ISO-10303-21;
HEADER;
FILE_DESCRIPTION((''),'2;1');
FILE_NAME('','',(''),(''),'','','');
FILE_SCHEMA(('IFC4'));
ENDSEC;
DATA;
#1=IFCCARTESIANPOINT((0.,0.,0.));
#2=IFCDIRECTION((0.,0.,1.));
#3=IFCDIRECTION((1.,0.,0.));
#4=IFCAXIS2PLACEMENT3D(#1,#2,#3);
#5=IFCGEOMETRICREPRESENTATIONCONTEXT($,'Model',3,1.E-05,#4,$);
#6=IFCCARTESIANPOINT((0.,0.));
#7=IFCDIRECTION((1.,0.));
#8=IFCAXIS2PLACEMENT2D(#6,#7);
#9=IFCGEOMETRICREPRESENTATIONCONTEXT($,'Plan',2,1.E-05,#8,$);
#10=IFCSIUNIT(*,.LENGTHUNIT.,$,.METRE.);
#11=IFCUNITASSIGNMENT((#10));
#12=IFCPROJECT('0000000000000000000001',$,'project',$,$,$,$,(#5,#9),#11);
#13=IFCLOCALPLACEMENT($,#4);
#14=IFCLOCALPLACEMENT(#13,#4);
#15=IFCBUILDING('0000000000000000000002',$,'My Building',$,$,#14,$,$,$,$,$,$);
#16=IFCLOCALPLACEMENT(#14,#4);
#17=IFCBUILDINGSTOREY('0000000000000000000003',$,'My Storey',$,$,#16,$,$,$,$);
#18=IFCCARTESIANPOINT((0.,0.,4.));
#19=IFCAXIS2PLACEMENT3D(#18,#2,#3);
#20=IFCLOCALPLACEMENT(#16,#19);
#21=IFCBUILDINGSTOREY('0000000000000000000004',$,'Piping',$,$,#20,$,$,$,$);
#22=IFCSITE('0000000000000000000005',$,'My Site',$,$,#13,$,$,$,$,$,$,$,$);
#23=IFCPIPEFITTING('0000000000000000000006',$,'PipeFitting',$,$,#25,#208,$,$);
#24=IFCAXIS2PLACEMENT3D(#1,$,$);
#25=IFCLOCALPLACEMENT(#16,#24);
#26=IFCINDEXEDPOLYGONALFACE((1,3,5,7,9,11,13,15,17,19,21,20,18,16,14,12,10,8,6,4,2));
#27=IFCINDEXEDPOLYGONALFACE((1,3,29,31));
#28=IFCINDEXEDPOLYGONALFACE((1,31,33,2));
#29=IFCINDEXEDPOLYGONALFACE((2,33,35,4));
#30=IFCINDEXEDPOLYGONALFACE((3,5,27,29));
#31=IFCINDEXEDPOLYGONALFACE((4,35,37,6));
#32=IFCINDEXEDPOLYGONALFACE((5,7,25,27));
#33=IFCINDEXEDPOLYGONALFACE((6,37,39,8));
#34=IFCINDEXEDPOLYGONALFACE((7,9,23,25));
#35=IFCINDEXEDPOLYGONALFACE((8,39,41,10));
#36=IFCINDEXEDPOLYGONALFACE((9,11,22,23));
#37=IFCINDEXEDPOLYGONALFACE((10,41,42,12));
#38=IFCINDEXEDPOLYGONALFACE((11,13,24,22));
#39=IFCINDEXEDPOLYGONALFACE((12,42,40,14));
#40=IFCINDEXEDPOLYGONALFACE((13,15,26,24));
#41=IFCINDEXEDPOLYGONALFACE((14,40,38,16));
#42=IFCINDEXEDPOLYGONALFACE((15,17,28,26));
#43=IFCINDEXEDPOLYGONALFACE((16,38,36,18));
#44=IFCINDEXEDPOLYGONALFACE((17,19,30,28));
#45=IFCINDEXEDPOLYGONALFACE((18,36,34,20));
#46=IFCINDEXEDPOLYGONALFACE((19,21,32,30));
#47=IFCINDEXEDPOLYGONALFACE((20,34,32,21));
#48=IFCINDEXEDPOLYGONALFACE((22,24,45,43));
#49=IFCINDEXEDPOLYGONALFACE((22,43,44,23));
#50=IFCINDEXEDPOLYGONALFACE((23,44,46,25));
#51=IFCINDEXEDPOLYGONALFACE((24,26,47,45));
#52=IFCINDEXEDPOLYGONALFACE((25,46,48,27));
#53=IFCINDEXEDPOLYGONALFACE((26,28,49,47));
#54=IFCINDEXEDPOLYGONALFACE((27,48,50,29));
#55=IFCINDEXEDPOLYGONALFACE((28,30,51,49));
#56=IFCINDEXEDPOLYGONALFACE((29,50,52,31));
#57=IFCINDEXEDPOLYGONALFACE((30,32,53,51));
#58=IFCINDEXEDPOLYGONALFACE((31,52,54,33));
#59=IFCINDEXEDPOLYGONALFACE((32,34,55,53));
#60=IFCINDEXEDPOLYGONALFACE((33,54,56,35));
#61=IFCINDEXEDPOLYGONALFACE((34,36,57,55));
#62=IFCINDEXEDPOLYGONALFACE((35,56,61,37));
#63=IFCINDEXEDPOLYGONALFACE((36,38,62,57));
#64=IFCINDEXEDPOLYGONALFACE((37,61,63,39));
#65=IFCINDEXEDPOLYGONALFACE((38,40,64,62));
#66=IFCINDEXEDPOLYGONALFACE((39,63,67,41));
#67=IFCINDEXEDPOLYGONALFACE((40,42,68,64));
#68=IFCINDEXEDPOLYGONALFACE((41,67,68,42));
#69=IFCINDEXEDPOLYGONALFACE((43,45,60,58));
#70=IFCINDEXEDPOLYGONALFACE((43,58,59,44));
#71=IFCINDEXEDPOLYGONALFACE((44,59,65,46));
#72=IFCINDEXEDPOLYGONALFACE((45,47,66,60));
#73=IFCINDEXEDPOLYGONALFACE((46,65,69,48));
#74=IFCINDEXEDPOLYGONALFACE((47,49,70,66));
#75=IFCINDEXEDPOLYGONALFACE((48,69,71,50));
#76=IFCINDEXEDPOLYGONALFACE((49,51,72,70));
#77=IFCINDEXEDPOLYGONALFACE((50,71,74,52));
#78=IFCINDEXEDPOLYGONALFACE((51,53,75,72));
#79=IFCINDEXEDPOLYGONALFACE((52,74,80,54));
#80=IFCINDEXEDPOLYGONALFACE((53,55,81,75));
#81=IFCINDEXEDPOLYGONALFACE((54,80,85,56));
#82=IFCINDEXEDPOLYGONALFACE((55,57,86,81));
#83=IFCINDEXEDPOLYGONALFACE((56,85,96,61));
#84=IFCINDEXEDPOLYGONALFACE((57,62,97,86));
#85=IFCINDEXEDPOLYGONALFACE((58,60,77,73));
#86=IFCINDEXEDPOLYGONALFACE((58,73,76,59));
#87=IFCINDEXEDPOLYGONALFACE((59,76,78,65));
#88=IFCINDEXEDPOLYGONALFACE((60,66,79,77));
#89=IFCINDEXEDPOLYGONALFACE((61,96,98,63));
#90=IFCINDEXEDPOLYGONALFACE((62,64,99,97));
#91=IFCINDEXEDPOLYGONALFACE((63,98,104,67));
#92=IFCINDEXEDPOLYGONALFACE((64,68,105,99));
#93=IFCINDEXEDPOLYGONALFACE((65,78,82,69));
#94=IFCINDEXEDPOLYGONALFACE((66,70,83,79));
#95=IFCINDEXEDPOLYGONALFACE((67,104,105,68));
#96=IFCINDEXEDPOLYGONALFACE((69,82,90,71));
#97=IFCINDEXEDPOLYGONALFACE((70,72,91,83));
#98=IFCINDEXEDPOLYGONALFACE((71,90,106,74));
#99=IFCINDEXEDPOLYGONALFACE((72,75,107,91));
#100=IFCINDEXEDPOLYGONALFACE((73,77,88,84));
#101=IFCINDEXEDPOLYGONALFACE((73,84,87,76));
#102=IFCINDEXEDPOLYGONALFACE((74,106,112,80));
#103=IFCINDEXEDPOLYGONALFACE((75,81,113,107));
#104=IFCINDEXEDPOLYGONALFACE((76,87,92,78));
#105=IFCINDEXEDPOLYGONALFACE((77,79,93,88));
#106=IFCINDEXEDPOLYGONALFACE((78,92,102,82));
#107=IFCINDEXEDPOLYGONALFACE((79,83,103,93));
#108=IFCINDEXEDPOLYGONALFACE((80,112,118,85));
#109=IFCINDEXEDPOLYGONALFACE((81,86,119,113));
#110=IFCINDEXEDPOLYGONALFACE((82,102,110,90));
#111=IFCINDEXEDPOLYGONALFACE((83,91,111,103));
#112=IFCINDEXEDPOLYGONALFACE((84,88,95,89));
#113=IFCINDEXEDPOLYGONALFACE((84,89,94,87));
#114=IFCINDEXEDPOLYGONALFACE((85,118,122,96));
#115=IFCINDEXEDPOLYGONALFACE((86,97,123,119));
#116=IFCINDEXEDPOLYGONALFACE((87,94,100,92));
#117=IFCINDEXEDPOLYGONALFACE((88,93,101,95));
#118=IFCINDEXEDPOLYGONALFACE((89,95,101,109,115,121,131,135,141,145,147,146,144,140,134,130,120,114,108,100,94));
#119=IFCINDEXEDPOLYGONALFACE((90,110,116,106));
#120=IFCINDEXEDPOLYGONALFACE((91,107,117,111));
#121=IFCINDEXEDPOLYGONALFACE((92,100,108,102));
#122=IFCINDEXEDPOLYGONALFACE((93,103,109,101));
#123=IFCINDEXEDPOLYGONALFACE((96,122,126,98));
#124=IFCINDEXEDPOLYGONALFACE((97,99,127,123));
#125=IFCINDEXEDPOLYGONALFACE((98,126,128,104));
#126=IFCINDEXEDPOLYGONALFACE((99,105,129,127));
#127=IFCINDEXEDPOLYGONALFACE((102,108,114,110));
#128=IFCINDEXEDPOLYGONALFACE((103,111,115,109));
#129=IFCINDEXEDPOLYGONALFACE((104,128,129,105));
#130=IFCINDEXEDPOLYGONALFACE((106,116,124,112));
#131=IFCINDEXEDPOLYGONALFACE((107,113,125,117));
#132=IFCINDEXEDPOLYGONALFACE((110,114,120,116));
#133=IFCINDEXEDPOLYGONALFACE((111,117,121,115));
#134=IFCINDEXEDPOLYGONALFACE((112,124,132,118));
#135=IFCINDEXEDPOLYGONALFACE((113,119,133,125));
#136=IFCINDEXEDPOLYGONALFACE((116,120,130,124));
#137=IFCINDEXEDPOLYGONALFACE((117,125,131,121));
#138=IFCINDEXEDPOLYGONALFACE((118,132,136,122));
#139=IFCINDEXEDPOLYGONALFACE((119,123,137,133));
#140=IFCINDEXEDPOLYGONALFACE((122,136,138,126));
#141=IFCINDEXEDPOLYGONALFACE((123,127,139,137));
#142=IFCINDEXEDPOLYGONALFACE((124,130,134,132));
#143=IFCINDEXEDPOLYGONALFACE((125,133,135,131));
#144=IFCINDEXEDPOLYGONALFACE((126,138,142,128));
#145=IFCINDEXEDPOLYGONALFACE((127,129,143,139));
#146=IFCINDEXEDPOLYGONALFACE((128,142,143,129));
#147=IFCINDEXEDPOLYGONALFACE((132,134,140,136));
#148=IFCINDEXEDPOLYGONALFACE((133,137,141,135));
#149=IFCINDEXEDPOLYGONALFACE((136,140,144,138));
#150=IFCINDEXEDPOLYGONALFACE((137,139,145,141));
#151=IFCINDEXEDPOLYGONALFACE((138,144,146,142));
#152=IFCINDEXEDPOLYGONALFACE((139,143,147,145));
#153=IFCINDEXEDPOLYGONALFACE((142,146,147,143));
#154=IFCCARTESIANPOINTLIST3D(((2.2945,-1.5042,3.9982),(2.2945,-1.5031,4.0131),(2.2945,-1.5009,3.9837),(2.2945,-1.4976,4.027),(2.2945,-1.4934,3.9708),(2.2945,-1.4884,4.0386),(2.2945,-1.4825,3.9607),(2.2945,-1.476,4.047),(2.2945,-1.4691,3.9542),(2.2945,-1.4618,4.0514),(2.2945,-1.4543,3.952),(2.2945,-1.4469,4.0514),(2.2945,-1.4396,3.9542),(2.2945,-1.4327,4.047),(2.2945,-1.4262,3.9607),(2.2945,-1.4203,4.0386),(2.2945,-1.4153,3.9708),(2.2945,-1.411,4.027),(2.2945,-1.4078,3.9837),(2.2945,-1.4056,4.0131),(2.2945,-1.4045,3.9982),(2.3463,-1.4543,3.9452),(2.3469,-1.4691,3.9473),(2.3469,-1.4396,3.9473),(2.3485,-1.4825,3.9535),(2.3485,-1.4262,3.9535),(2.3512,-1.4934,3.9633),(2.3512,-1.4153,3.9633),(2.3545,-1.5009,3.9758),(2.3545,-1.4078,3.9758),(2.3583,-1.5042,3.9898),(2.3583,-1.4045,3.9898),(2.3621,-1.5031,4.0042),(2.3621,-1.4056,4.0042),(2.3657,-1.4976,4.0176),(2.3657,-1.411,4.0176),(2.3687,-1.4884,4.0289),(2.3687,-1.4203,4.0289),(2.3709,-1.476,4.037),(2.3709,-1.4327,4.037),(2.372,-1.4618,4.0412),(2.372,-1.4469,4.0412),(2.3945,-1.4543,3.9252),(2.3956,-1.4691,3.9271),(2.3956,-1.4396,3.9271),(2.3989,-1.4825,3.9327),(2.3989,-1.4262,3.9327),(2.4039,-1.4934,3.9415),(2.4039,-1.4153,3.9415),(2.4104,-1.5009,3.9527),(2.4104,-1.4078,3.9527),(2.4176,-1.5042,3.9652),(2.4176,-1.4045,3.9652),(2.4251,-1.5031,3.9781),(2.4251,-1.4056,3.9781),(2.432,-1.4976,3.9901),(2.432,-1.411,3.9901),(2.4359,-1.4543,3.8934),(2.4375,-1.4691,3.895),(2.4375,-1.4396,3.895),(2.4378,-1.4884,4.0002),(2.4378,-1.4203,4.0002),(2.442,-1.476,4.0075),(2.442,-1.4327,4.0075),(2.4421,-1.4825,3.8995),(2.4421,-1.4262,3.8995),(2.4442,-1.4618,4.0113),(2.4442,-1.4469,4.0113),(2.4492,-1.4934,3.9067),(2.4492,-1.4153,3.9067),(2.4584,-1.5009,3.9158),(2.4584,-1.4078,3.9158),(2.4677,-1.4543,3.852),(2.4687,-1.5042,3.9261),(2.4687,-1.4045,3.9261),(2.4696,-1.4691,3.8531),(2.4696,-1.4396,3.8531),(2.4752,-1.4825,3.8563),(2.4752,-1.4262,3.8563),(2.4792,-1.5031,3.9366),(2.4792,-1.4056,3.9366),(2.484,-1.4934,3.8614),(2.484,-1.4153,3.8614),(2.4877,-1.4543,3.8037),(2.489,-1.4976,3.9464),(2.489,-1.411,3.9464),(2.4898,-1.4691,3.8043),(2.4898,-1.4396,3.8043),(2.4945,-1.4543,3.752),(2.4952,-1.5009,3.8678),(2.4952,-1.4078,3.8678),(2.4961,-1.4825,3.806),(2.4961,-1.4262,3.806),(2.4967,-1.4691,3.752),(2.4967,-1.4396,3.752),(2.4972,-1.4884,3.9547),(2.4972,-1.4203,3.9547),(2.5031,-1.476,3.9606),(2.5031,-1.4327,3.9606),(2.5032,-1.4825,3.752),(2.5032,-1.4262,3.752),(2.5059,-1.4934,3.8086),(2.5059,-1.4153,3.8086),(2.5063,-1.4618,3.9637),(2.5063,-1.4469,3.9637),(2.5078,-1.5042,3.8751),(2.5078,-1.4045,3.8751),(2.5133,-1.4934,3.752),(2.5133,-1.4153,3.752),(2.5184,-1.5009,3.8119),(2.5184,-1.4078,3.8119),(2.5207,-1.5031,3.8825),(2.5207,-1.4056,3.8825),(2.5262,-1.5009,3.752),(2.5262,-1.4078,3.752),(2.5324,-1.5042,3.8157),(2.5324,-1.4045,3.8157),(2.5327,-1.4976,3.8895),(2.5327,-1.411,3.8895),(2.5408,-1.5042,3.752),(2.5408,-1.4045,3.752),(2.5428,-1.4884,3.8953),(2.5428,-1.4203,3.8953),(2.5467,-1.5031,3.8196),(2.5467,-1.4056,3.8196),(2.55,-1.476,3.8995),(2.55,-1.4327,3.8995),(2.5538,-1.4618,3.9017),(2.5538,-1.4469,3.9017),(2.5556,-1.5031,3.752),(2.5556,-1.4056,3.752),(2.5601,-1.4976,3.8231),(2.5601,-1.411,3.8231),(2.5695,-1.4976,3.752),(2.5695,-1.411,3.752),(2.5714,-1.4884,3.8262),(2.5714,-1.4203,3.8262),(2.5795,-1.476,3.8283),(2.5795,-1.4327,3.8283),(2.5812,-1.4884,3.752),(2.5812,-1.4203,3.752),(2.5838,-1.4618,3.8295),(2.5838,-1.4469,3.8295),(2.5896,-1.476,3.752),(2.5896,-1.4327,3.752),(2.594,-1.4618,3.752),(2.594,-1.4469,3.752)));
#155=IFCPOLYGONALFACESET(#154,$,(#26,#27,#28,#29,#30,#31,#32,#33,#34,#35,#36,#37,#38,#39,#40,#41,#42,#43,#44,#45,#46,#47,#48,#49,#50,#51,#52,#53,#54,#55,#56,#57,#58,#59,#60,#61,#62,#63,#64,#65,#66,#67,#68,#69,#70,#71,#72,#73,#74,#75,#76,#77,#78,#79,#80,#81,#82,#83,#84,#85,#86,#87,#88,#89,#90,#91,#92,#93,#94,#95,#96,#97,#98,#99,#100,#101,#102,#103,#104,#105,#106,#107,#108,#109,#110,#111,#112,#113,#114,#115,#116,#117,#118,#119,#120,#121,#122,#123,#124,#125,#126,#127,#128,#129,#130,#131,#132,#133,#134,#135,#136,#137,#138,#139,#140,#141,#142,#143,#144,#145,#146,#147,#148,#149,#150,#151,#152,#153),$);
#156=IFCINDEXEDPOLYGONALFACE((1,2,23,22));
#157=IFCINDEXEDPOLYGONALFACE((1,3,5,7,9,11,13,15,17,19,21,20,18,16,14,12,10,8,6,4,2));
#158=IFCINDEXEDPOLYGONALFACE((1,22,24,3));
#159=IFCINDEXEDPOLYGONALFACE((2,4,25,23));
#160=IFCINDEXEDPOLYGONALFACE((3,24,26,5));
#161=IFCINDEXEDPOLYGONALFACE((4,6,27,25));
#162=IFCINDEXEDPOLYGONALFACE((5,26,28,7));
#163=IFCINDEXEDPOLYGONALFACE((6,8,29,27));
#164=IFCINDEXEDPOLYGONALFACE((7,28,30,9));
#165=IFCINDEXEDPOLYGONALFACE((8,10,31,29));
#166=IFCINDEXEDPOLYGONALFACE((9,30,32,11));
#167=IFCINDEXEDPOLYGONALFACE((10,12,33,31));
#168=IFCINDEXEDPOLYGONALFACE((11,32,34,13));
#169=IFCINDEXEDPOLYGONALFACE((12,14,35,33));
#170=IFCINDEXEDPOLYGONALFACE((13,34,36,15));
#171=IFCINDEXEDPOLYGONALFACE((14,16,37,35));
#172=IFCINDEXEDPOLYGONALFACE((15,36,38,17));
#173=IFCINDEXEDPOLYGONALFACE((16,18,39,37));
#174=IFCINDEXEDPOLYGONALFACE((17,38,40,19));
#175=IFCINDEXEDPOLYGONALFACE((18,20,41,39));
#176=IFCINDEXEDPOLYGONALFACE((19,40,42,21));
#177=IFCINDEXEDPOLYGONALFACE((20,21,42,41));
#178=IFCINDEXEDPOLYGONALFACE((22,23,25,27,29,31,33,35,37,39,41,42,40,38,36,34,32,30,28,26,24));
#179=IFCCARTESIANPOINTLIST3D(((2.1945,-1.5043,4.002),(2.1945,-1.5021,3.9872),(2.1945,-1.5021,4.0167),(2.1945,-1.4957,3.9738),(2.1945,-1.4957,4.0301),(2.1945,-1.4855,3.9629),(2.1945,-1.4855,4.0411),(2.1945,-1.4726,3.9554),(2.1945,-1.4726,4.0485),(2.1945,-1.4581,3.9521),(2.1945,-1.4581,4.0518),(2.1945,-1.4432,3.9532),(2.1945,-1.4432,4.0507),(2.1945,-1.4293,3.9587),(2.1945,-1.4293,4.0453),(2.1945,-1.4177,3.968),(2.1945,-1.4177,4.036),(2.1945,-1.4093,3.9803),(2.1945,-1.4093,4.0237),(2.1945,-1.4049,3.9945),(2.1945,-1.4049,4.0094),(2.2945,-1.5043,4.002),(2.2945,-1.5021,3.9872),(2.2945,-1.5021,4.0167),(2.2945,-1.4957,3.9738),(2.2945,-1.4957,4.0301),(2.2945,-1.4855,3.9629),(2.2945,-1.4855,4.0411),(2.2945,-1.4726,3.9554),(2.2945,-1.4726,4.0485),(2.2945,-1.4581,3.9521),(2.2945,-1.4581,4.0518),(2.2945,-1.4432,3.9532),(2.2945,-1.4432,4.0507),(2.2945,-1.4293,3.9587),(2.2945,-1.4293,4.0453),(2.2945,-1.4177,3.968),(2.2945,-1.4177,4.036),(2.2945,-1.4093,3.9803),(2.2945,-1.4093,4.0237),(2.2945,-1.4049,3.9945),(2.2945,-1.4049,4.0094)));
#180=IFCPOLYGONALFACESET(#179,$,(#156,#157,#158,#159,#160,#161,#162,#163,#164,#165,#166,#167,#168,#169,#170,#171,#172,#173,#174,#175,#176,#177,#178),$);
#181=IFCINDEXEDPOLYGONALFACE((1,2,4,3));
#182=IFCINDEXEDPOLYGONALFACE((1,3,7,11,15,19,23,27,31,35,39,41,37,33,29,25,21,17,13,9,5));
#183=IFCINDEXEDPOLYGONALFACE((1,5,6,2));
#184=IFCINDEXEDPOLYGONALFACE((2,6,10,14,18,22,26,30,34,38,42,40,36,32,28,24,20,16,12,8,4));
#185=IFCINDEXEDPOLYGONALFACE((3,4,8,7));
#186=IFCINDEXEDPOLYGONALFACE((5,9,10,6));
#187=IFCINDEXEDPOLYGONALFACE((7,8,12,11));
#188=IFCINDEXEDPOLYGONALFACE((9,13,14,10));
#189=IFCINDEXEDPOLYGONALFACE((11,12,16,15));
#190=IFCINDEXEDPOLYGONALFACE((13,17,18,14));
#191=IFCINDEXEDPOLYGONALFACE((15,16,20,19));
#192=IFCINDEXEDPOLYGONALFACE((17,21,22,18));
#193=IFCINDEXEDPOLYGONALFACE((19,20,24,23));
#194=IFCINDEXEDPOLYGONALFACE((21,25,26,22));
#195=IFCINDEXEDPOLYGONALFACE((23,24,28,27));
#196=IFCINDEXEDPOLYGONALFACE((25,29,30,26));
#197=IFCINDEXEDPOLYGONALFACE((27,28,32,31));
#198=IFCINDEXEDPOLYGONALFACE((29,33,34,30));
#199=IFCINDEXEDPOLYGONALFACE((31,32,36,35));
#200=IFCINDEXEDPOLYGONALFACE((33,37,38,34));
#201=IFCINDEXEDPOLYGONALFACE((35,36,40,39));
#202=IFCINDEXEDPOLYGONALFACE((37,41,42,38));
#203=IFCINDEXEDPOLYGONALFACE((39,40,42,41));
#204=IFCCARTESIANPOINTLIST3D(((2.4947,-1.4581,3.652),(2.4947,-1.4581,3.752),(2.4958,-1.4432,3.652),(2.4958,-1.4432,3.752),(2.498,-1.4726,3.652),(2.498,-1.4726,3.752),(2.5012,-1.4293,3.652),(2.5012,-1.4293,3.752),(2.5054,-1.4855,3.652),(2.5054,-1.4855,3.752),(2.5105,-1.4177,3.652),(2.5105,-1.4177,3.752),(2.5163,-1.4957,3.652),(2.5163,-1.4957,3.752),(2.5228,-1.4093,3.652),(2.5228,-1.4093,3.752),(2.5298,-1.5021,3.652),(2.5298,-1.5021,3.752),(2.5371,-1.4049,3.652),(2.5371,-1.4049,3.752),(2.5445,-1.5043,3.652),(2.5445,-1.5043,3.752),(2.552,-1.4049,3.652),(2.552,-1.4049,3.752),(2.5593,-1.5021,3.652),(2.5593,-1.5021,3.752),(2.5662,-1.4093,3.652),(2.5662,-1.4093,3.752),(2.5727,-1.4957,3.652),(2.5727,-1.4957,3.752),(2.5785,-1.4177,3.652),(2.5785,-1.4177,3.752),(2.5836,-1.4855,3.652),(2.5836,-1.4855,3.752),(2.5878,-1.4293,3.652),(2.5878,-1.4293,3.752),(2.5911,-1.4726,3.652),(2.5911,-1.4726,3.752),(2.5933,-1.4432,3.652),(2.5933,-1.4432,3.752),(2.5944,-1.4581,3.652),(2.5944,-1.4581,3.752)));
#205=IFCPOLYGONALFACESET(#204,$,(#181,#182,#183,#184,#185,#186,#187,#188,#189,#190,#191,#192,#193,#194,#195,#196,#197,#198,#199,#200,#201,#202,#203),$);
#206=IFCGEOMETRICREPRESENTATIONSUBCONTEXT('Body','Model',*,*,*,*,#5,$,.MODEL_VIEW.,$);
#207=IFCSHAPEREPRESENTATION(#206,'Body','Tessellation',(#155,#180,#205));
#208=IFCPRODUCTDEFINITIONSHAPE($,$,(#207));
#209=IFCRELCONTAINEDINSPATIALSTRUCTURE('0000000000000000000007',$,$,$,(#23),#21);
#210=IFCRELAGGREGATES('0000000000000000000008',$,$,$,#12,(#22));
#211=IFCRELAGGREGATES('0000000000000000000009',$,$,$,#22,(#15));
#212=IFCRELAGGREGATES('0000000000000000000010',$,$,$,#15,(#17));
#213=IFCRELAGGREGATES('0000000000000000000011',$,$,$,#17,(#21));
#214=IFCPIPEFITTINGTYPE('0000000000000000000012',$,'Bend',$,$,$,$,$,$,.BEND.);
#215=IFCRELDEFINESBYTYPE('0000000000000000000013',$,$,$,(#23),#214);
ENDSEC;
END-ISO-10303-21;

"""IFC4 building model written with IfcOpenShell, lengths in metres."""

from ifc_helpers import new_model, entity, si_unit, frame, origin_with_axes, origin_2d_with_axis, place, context, subcontext, project, spatial, line, indexed_curve, circle, outline, extrude, source, transform, mapped, type_object, type_shapes, element, save


model = new_model("IFC4")

# Units and contexts
model_context = context("Model", 3, precision=1e-05, world=origin_with_axes())
plan_context = context("Plan", 2, precision=1e-05, world=origin_2d_with_axis())
body_context = subcontext(model_context, "Body", "Model", "MODEL_VIEW")
ifc_project = project(units=[si_unit("LENGTHUNIT", "METRE")], contexts=[model_context, plan_context])

# Site, building, storeys
site_placement = place(None, origin_with_axes())
site = spatial("IfcSite", under=ifc_project, at=site_placement, Name="My Site")
building_placement = place(site_placement, origin_with_axes())
building = spatial("IfcBuilding", under=site, at=building_placement, Name="My Building")
storey_1_placement = place(building_placement, origin_with_axes())
storey_1 = spatial("IfcBuildingStorey", under=building, at=storey_1_placement, Name="My Storey")
storey_2_placement = place(storey_1_placement, frame((0.0, 0.0, 4.0), z_axis=(0.0, 0.0, 1.0), x_axis=(1.0, 0.0, 0.0)))
storey_2 = spatial("IfcBuildingStorey", under=storey_1, at=storey_2_placement, Name="Piping")

# Shared definitions
pipe_fitting_type_1 = type_object("IfcPipeFittingType", Name="Bend", PredefinedType="BEND")
shared_shape = source(origin_with_axes(), body_context, "Body", "SolidModel", [
    entity("IfcSweptDiskSolid", entity("IfcIndexedPolyCurve", entity("IfcCartesianPointList3D", [[0.0, 0.0, -0.1], [0.0, -0.0732, -0.2768], [0.0, -0.25, -0.35]]), [entity("IfcArcIndex", [1, 2, 3])]), 0.05),
    extrude(circle(Radius=0.05), origin_with_axes(), (0.0, 0.0, -1.0), 0.1),
    extrude(circle(Radius=0.05), frame((0.0, -0.25, -0.35), z_axis=(0.0, -1.0, 0.0), x_axis=(1.0, 0.0, 0.0)), (0.0, 0.0, 1.0), 0.1),
])
type_shapes(pipe_fitting_type_1, [shared_shape])

# Pipe fitting, opening
pipe_fitting_1_placement = place(storey_2_placement, frame((2.1945, -1.4543, 0.002), z_axis=(-1.0, 0.0, 0.0), x_axis=(0.0, -1.0, 0.0)))
pipe_fitting_1 = element("IfcPipeFitting", 1, at=pipe_fitting_1_placement, inside=storey_2, type_object=pipe_fitting_type_1, Name="PipeFitting", context=body_context, shape_type="MappedRepresentation", body=[
    mapped(shared_shape, transform((0.0, 0.0, 0.0), x_axis=(1.0, 0.0, 0.0), y_axis=(0.0, 1.0, 0.0), z_axis=(0.0, 0.0, 1.0), scale=1.0)),
])
opening_1_placement = place(pipe_fitting_1_placement, frame((-1.4543, -4.002, 2.1945), z_axis=(0.0, 1.0, 0.0), x_axis=(0.0, 0.0, -1.0)))
element("IfcOpeningElement", 2, at=opening_1_placement, cuts=pipe_fitting_1, PredefinedType="OPENING", context=body_context, shape_type="SweptSolid", body=[
    extrude(outline(indexed_curve([(0.0, 0.0), (0.5, 0.0), (0.5, 0.5), (0.0, 0.5)], segments=[line(1, 2, 3, 4, 1)])), origin_with_axes(), (0.0, 0.0, 1.0), 0.5),
])

save(model, "model.ifc")
